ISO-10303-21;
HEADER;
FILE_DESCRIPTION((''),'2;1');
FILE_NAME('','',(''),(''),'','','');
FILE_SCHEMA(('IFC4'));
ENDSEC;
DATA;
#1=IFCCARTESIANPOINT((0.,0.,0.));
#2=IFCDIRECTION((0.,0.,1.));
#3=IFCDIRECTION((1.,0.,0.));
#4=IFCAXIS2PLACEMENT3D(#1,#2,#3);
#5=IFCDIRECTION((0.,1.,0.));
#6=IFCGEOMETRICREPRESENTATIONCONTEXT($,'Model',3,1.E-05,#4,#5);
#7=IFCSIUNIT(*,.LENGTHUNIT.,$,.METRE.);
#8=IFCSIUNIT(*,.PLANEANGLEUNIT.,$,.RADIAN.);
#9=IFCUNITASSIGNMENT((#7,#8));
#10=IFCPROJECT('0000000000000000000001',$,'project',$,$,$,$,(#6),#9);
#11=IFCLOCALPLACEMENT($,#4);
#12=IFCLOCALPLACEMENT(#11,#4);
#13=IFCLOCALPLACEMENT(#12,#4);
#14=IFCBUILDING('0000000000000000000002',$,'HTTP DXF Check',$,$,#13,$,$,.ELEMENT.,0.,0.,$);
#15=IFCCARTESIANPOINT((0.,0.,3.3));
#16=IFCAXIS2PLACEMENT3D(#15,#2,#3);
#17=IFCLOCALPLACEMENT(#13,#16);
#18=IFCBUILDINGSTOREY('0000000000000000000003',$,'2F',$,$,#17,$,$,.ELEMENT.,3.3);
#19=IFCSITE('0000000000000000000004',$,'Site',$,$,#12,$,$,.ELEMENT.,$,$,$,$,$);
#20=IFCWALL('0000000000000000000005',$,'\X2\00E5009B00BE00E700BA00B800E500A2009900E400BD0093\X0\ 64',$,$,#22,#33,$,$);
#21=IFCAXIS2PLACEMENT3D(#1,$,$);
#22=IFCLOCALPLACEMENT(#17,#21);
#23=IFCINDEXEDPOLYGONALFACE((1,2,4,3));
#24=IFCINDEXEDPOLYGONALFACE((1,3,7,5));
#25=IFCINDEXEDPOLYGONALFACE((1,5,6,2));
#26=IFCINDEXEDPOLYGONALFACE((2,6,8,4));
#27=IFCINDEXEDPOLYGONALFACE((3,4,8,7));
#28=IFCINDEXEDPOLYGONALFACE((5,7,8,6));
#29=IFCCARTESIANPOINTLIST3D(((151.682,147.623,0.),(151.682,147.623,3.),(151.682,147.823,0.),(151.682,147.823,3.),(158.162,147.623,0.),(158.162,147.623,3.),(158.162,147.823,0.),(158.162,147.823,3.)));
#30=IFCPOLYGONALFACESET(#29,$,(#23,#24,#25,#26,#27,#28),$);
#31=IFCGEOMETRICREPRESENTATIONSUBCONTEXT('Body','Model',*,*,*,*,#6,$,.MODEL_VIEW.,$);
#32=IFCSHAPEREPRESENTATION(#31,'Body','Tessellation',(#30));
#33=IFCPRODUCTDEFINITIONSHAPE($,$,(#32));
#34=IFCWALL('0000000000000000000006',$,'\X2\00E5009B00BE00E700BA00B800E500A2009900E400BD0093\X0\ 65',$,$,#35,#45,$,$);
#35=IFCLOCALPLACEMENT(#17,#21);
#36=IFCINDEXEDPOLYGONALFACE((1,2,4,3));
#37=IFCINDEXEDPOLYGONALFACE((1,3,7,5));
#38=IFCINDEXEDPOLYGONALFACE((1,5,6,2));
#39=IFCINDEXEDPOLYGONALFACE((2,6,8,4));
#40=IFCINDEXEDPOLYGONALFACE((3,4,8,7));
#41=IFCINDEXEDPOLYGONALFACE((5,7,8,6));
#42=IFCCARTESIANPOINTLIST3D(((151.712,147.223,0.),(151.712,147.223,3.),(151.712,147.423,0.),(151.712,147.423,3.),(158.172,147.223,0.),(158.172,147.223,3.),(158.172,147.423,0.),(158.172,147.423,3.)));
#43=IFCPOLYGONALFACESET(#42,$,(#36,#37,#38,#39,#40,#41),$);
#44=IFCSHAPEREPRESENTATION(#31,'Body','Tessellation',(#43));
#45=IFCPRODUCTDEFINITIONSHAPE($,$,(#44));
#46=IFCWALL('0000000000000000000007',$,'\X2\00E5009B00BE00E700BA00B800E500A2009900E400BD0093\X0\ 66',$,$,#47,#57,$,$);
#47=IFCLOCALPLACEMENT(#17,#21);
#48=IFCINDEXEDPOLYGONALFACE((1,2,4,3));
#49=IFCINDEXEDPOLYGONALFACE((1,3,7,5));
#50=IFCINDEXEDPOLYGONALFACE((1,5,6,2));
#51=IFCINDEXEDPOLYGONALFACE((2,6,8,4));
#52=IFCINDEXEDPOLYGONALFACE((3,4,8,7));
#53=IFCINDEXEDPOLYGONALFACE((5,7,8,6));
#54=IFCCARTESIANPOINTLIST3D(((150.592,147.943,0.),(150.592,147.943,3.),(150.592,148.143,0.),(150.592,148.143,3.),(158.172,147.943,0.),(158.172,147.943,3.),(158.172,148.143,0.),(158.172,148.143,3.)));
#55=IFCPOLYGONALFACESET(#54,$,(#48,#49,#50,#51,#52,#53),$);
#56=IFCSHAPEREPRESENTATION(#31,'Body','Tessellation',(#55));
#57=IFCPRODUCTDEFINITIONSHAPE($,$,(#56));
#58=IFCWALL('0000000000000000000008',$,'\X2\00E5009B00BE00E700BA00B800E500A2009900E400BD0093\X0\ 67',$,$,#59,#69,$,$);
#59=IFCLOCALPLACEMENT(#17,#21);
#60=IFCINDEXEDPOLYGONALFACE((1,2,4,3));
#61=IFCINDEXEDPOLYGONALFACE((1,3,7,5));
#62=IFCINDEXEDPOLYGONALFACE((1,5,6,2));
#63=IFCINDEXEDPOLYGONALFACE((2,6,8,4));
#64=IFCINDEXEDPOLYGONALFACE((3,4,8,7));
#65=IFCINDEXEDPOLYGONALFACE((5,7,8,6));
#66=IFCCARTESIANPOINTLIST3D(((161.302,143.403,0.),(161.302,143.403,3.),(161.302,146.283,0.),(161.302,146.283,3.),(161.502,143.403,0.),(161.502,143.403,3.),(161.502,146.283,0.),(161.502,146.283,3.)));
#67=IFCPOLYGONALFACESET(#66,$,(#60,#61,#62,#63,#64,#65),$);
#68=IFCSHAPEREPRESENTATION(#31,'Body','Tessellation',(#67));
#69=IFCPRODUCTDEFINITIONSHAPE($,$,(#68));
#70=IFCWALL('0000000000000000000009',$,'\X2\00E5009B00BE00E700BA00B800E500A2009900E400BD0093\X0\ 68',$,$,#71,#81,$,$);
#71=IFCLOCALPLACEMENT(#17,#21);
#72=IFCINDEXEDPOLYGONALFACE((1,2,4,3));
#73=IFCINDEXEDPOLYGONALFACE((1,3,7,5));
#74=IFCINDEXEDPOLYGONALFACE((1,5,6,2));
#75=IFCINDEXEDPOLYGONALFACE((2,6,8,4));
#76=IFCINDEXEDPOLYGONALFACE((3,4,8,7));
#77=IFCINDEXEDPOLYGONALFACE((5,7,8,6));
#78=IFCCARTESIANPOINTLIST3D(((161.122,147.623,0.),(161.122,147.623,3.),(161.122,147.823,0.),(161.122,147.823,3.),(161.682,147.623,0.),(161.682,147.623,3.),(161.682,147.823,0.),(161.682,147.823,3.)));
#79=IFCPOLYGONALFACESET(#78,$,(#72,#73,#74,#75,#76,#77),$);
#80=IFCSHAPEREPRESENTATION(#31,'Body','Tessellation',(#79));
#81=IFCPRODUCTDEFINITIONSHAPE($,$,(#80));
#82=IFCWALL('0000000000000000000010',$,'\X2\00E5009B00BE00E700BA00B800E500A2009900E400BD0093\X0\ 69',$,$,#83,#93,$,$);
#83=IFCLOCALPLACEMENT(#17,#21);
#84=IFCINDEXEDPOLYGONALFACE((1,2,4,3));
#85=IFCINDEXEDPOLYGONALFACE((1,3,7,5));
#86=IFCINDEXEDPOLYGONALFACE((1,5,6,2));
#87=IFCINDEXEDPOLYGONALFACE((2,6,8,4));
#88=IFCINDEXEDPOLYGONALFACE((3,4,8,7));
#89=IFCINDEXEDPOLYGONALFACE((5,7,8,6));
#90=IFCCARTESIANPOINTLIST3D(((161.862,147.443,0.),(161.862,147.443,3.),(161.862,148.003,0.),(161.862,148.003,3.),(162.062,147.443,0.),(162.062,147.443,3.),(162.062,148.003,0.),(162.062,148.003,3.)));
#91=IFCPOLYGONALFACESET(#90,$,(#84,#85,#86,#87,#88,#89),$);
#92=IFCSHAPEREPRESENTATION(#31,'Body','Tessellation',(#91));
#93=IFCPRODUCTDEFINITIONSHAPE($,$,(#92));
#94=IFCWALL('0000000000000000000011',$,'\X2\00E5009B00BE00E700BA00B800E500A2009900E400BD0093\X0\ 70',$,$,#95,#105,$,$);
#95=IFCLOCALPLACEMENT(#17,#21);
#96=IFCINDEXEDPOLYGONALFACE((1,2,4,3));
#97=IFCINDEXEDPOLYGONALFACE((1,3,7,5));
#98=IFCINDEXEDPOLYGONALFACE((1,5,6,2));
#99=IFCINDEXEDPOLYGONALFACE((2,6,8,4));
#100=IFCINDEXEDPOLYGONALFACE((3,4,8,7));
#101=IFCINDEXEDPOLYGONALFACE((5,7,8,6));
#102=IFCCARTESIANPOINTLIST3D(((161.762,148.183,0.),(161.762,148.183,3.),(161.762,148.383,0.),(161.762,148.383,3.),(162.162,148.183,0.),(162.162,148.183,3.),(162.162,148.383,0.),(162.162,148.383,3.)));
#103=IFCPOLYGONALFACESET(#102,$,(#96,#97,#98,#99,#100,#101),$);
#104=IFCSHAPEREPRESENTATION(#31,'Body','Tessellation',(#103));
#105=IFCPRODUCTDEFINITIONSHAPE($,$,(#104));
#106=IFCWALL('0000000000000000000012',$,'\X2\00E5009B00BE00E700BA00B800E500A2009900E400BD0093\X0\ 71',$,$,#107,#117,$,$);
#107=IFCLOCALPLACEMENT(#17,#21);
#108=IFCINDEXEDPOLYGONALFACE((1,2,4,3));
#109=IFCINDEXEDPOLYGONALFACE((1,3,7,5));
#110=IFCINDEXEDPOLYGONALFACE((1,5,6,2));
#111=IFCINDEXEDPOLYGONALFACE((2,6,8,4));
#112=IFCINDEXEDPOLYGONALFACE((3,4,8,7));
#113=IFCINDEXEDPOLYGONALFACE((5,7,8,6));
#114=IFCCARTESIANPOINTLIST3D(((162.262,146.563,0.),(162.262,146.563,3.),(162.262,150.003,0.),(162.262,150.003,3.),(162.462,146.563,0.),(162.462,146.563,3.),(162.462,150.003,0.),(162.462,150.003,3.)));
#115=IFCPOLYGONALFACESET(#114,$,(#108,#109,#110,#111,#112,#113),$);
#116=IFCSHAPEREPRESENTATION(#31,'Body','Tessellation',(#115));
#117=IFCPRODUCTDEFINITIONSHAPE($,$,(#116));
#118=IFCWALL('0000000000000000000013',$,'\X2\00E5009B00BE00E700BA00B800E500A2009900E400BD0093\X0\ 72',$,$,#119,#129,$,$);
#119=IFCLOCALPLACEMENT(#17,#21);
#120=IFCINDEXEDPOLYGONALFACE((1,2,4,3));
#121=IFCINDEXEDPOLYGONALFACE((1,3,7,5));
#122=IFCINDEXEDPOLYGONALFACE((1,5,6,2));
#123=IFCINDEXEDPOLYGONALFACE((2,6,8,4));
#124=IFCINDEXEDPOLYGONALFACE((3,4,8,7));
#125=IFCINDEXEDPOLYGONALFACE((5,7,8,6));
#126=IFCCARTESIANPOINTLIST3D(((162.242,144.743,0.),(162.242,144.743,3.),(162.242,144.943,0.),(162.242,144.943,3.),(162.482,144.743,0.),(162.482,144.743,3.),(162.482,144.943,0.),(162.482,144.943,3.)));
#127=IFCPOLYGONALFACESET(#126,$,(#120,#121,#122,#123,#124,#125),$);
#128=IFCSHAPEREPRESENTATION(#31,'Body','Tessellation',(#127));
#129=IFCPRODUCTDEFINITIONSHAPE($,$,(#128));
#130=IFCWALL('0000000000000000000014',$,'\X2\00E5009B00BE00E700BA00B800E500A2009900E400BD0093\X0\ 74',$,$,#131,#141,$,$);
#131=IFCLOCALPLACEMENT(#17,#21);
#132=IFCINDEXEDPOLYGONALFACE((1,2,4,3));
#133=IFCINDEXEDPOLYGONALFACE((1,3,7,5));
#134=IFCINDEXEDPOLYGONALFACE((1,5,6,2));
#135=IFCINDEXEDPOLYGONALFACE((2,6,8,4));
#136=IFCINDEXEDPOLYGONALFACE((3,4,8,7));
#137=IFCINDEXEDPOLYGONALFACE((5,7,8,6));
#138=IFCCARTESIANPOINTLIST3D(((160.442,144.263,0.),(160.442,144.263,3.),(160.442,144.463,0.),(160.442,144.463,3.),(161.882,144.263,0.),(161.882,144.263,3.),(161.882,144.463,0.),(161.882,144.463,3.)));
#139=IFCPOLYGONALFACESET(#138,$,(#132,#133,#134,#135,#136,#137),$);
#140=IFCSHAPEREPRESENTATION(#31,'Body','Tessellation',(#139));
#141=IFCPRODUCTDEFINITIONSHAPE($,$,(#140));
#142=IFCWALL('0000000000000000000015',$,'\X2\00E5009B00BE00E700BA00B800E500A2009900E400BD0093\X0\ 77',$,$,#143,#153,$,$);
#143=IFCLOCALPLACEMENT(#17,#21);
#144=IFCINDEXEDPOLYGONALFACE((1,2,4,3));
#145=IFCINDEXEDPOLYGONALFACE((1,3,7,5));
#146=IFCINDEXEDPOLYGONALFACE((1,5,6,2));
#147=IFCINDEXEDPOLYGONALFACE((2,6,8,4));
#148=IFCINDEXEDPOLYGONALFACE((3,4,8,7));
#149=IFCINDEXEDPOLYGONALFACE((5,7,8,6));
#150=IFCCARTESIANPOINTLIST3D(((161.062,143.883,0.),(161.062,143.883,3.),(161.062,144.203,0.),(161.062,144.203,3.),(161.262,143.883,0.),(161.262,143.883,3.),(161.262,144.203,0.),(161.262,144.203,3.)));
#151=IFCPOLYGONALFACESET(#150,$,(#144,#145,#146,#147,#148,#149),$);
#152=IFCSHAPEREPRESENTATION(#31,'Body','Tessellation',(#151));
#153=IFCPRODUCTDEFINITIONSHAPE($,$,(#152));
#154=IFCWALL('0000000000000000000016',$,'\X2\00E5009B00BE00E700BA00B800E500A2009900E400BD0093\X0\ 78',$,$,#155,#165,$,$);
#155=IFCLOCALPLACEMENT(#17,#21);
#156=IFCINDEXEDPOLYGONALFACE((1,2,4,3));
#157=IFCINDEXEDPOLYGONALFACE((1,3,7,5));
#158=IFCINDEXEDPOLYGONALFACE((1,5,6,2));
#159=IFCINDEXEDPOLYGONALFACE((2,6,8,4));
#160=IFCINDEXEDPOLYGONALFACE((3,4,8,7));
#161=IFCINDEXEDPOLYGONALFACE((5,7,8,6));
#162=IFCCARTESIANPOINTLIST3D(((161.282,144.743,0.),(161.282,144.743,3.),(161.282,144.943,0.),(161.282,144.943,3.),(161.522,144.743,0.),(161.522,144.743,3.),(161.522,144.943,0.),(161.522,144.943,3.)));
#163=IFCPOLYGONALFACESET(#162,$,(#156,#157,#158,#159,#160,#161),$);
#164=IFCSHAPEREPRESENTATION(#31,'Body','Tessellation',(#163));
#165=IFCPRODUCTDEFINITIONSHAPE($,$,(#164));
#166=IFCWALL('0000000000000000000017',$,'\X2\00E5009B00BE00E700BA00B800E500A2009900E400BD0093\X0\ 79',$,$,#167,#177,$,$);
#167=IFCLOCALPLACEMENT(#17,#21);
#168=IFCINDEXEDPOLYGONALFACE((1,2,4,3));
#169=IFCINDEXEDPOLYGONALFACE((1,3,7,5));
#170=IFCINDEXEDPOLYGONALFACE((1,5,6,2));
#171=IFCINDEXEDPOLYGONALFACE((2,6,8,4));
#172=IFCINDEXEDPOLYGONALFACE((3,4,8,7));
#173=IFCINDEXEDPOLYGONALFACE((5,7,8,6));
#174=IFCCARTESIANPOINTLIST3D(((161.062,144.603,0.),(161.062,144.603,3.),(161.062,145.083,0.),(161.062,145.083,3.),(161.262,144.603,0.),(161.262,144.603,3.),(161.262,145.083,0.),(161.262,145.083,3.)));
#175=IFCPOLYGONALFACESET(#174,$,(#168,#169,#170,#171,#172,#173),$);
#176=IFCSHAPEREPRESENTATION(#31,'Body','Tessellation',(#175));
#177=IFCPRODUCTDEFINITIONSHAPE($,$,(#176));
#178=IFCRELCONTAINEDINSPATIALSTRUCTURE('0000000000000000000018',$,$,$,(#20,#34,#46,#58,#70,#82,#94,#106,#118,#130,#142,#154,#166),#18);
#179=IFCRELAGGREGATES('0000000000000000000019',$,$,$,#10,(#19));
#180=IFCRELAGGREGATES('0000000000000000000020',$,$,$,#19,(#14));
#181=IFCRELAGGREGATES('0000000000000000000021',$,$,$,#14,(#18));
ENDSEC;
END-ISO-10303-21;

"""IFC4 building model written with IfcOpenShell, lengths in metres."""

from ifc_helpers import new_model, si_unit, direction, frame, frame_2d, origin_with_axes, place, context, subcontext, project, spatial, rectangle, extrude, element, save


model = new_model("IFC4")

# Units and contexts
model_context = context("Model", 3, precision=1e-05, world=origin_with_axes(), true_north=direction((0.0, 1.0, 0.0)))
body_context = subcontext(model_context, "Body", "Model", "MODEL_VIEW")
ifc_project = project(units=[si_unit("LENGTHUNIT", "METRE"), si_unit("PLANEANGLEUNIT", "RADIAN")], contexts=[model_context])

# Site, building, storey
placement = place(None, origin_with_axes())
site_placement = place(placement, origin_with_axes())
site = spatial("IfcSite", under=ifc_project, at=site_placement, Name="Site", CompositionType="ELEMENT")
building_placement = place(site_placement, origin_with_axes())
building = spatial("IfcBuilding", under=site, at=building_placement, Name="HTTP DXF Check", CompositionType="ELEMENT", ElevationOfRefHeight=0.0, ElevationOfTerrain=0.0)
storey_placement = place(building_placement, frame((0.0, 0.0, 3.3), z_axis=(0.0, 0.0, 1.0), x_axis=(1.0, 0.0, 0.0)))
storey = spatial("IfcBuildingStorey", under=building, at=storey_placement, Name="2F", CompositionType="ELEMENT", Elevation=3.3)

# Walls
wall_1_placement = place(storey_placement, frame((154.922, 147.723, 0.0), z_axis=(0.0, 0.0, 1.0), x_axis=(1.0, 0.0, 0.0)))
element("IfcWall", 1, at=wall_1_placement, inside=storey, Name="å\u009b¾çº¸å¢\u0099ä½\u0093 64", context=body_context, shape_type="SweptSolid", body=[
    extrude(rectangle(XDim=6.48, YDim=0.2, at=frame_2d((0.0, 0.0), x_axis=(1.0, 0.0, 0.0))), frame((0.0, 0.0, 0.0), z_axis=(0.0, 0.0, 1.0)), (0.0, 0.0, 1.0), 3.0),
])
wall_2_placement = place(storey_placement, frame((154.942, 147.323, 0.0), z_axis=(0.0, 0.0, 1.0), x_axis=(1.0, 0.0, 0.0)))
element("IfcWall", 2, at=wall_2_placement, inside=storey, Name="å\u009b¾çº¸å¢\u0099ä½\u0093 65", context=body_context, shape_type="SweptSolid", body=[
    extrude(rectangle(XDim=6.46, YDim=0.2, at=frame_2d((0.0, 0.0), x_axis=(1.0, 0.0, 0.0))), frame((0.0, 0.0, 0.0), z_axis=(0.0, 0.0, 1.0)), (0.0, 0.0, 1.0), 3.0),
])
wall_3_placement = place(storey_placement, frame((154.382, 148.043, 0.0), z_axis=(0.0, 0.0, 1.0), x_axis=(1.0, 0.0, 0.0)))
element("IfcWall", 3, at=wall_3_placement, inside=storey, Name="å\u009b¾çº¸å¢\u0099ä½\u0093 66", context=body_context, shape_type="SweptSolid", body=[
    extrude(rectangle(XDim=7.58, YDim=0.2, at=frame_2d((0.0, 0.0), x_axis=(1.0, 0.0, 0.0))), frame((0.0, 0.0, 0.0), z_axis=(0.0, 0.0, 1.0)), (0.0, 0.0, 1.0), 3.0),
])
wall_4_placement = place(storey_placement, frame((161.402, 144.843, 0.0), z_axis=(0.0, 0.0, 1.0), x_axis=(0.0, 1.0, 0.0)))
element("IfcWall", 4, at=wall_4_placement, inside=storey, Name="å\u009b¾çº¸å¢\u0099ä½\u0093 67", context=body_context, shape_type="SweptSolid", body=[
    extrude(rectangle(XDim=2.88, YDim=0.2, at=frame_2d((0.0, 0.0), x_axis=(1.0, 0.0, 0.0))), frame((0.0, 0.0, 0.0), z_axis=(0.0, 0.0, 1.0)), (0.0, 0.0, 1.0), 3.0),
])
for number, where, z_axis, x_axis, name in (
    (5, (161.402, 147.723, 0.0), (0.0, 0.0, 1.0), (1.0, 0.0, 0.0), "å\u009b¾çº¸å¢\u0099ä½\u0093 68"),
    (6, (161.962, 147.723, 0.0), (0.0, 0.0, 1.0), (0.0, 1.0, 0.0), "å\u009b¾çº¸å¢\u0099ä½\u0093 69"),
):
    element("IfcWall", number, at=place(storey_placement, frame(where, z_axis=z_axis, x_axis=x_axis)), inside=storey, Name=name, context=body_context, shape_type="SweptSolid", body=[
        extrude(rectangle(XDim=0.56, YDim=0.2, at=frame_2d((0.0, 0.0), x_axis=(1.0, 0.0, 0.0))), frame((0.0, 0.0, 0.0), z_axis=(0.0, 0.0, 1.0)), (0.0, 0.0, 1.0), 3.0),
    ])
wall_5_placement = place(storey_placement, frame((161.962, 148.283, 0.0), z_axis=(0.0, 0.0, 1.0), x_axis=(1.0, 0.0, 0.0)))
element("IfcWall", 7, at=wall_5_placement, inside=storey, Name="å\u009b¾çº¸å¢\u0099ä½\u0093 70", context=body_context, shape_type="SweptSolid", body=[
    extrude(rectangle(XDim=0.4, YDim=0.2, at=frame_2d((0.0, 0.0), x_axis=(1.0, 0.0, 0.0))), frame((0.0, 0.0, 0.0), z_axis=(0.0, 0.0, 1.0)), (0.0, 0.0, 1.0), 3.0),
])
wall_6_placement = place(storey_placement, frame((162.362, 148.283, 0.0), z_axis=(0.0, 0.0, 1.0), x_axis=(0.0, -1.0, 0.0)))
element("IfcWall", 8, at=wall_6_placement, inside=storey, Name="å\u009b¾çº¸å¢\u0099ä½\u0093 71", context=body_context, shape_type="SweptSolid", body=[
    extrude(rectangle(XDim=3.44, YDim=0.2, at=frame_2d((0.0, 0.0), x_axis=(1.0, 0.0, 0.0))), frame((0.0, 0.0, 0.0), z_axis=(0.0, 0.0, 1.0)), (0.0, 0.0, 1.0), 3.0),
])
wall_7_placement = place(storey_placement, frame((162.362, 144.843, 0.0), z_axis=(0.0, 0.0, 1.0), x_axis=(1.0, 0.0, 0.0)))
element("IfcWall", 9, at=wall_7_placement, inside=storey, Name="å\u009b¾çº¸å¢\u0099ä½\u0093 72", context=body_context, shape_type="SweptSolid", body=[
    extrude(rectangle(XDim=0.24, YDim=0.2, at=frame_2d((0.0, 0.0), x_axis=(1.0, 0.0, 0.0))), frame((0.0, 0.0, 0.0), z_axis=(0.0, 0.0, 1.0)), (0.0, 0.0, 1.0), 3.0),
])
wall_8_placement = place(storey_placement, frame((161.162, 144.363, 0.0), z_axis=(0.0, 0.0, 1.0), x_axis=(1.0, 0.0, 0.0)))
element("IfcWall", 10, at=wall_8_placement, inside=storey, Name="å\u009b¾çº¸å¢\u0099ä½\u0093 74", context=body_context, shape_type="SweptSolid", body=[
    extrude(rectangle(XDim=1.44, YDim=0.2, at=frame_2d((0.0, 0.0), x_axis=(1.0, 0.0, 0.0))), frame((0.0, 0.0, 0.0), z_axis=(0.0, 0.0, 1.0)), (0.0, 0.0, 1.0), 3.0),
])
wall_9_placement = place(storey_placement, frame((161.162, 144.043, 0.0), z_axis=(0.0, 0.0, 1.0), x_axis=(0.0, 1.0, 0.0)))
element("IfcWall", 11, at=wall_9_placement, inside=storey, Name="å\u009b¾çº¸å¢\u0099ä½\u0093 77", context=body_context, shape_type="SweptSolid", body=[
    extrude(rectangle(XDim=0.32, YDim=0.2, at=frame_2d((0.0, 0.0), x_axis=(1.0, 0.0, 0.0))), frame((0.0, 0.0, 0.0), z_axis=(0.0, 0.0, 1.0)), (0.0, 0.0, 1.0), 3.0),
])
wall_10_placement = place(storey_placement, frame((161.402, 144.843, 0.0), z_axis=(0.0, 0.0, 1.0), x_axis=(-1.0, 0.0, 0.0)))
element("IfcWall", 12, at=wall_10_placement, inside=storey, Name="å\u009b¾çº¸å¢\u0099ä½\u0093 78", context=body_context, shape_type="SweptSolid", body=[
    extrude(rectangle(XDim=0.24, YDim=0.2, at=frame_2d((0.0, 0.0), x_axis=(1.0, 0.0, 0.0))), frame((0.0, 0.0, 0.0), z_axis=(0.0, 0.0, 1.0)), (0.0, 0.0, 1.0), 3.0),
])
wall_11_placement = place(storey_placement, frame((161.162, 144.843, 0.0), z_axis=(0.0, 0.0, 1.0), x_axis=(0.0, -1.0, 0.0)))
element("IfcWall", 13, at=wall_11_placement, inside=storey, Name="å\u009b¾çº¸å¢\u0099ä½\u0093 79", context=body_context, shape_type="SweptSolid", body=[
    extrude(rectangle(XDim=0.48, YDim=0.2, at=frame_2d((0.0, 0.0), x_axis=(1.0, 0.0, 0.0))), frame((0.0, 0.0, 0.0), z_axis=(0.0, 0.0, 1.0)), (0.0, 0.0, 1.0), 3.0),
])

save(model, "model.ifc")
